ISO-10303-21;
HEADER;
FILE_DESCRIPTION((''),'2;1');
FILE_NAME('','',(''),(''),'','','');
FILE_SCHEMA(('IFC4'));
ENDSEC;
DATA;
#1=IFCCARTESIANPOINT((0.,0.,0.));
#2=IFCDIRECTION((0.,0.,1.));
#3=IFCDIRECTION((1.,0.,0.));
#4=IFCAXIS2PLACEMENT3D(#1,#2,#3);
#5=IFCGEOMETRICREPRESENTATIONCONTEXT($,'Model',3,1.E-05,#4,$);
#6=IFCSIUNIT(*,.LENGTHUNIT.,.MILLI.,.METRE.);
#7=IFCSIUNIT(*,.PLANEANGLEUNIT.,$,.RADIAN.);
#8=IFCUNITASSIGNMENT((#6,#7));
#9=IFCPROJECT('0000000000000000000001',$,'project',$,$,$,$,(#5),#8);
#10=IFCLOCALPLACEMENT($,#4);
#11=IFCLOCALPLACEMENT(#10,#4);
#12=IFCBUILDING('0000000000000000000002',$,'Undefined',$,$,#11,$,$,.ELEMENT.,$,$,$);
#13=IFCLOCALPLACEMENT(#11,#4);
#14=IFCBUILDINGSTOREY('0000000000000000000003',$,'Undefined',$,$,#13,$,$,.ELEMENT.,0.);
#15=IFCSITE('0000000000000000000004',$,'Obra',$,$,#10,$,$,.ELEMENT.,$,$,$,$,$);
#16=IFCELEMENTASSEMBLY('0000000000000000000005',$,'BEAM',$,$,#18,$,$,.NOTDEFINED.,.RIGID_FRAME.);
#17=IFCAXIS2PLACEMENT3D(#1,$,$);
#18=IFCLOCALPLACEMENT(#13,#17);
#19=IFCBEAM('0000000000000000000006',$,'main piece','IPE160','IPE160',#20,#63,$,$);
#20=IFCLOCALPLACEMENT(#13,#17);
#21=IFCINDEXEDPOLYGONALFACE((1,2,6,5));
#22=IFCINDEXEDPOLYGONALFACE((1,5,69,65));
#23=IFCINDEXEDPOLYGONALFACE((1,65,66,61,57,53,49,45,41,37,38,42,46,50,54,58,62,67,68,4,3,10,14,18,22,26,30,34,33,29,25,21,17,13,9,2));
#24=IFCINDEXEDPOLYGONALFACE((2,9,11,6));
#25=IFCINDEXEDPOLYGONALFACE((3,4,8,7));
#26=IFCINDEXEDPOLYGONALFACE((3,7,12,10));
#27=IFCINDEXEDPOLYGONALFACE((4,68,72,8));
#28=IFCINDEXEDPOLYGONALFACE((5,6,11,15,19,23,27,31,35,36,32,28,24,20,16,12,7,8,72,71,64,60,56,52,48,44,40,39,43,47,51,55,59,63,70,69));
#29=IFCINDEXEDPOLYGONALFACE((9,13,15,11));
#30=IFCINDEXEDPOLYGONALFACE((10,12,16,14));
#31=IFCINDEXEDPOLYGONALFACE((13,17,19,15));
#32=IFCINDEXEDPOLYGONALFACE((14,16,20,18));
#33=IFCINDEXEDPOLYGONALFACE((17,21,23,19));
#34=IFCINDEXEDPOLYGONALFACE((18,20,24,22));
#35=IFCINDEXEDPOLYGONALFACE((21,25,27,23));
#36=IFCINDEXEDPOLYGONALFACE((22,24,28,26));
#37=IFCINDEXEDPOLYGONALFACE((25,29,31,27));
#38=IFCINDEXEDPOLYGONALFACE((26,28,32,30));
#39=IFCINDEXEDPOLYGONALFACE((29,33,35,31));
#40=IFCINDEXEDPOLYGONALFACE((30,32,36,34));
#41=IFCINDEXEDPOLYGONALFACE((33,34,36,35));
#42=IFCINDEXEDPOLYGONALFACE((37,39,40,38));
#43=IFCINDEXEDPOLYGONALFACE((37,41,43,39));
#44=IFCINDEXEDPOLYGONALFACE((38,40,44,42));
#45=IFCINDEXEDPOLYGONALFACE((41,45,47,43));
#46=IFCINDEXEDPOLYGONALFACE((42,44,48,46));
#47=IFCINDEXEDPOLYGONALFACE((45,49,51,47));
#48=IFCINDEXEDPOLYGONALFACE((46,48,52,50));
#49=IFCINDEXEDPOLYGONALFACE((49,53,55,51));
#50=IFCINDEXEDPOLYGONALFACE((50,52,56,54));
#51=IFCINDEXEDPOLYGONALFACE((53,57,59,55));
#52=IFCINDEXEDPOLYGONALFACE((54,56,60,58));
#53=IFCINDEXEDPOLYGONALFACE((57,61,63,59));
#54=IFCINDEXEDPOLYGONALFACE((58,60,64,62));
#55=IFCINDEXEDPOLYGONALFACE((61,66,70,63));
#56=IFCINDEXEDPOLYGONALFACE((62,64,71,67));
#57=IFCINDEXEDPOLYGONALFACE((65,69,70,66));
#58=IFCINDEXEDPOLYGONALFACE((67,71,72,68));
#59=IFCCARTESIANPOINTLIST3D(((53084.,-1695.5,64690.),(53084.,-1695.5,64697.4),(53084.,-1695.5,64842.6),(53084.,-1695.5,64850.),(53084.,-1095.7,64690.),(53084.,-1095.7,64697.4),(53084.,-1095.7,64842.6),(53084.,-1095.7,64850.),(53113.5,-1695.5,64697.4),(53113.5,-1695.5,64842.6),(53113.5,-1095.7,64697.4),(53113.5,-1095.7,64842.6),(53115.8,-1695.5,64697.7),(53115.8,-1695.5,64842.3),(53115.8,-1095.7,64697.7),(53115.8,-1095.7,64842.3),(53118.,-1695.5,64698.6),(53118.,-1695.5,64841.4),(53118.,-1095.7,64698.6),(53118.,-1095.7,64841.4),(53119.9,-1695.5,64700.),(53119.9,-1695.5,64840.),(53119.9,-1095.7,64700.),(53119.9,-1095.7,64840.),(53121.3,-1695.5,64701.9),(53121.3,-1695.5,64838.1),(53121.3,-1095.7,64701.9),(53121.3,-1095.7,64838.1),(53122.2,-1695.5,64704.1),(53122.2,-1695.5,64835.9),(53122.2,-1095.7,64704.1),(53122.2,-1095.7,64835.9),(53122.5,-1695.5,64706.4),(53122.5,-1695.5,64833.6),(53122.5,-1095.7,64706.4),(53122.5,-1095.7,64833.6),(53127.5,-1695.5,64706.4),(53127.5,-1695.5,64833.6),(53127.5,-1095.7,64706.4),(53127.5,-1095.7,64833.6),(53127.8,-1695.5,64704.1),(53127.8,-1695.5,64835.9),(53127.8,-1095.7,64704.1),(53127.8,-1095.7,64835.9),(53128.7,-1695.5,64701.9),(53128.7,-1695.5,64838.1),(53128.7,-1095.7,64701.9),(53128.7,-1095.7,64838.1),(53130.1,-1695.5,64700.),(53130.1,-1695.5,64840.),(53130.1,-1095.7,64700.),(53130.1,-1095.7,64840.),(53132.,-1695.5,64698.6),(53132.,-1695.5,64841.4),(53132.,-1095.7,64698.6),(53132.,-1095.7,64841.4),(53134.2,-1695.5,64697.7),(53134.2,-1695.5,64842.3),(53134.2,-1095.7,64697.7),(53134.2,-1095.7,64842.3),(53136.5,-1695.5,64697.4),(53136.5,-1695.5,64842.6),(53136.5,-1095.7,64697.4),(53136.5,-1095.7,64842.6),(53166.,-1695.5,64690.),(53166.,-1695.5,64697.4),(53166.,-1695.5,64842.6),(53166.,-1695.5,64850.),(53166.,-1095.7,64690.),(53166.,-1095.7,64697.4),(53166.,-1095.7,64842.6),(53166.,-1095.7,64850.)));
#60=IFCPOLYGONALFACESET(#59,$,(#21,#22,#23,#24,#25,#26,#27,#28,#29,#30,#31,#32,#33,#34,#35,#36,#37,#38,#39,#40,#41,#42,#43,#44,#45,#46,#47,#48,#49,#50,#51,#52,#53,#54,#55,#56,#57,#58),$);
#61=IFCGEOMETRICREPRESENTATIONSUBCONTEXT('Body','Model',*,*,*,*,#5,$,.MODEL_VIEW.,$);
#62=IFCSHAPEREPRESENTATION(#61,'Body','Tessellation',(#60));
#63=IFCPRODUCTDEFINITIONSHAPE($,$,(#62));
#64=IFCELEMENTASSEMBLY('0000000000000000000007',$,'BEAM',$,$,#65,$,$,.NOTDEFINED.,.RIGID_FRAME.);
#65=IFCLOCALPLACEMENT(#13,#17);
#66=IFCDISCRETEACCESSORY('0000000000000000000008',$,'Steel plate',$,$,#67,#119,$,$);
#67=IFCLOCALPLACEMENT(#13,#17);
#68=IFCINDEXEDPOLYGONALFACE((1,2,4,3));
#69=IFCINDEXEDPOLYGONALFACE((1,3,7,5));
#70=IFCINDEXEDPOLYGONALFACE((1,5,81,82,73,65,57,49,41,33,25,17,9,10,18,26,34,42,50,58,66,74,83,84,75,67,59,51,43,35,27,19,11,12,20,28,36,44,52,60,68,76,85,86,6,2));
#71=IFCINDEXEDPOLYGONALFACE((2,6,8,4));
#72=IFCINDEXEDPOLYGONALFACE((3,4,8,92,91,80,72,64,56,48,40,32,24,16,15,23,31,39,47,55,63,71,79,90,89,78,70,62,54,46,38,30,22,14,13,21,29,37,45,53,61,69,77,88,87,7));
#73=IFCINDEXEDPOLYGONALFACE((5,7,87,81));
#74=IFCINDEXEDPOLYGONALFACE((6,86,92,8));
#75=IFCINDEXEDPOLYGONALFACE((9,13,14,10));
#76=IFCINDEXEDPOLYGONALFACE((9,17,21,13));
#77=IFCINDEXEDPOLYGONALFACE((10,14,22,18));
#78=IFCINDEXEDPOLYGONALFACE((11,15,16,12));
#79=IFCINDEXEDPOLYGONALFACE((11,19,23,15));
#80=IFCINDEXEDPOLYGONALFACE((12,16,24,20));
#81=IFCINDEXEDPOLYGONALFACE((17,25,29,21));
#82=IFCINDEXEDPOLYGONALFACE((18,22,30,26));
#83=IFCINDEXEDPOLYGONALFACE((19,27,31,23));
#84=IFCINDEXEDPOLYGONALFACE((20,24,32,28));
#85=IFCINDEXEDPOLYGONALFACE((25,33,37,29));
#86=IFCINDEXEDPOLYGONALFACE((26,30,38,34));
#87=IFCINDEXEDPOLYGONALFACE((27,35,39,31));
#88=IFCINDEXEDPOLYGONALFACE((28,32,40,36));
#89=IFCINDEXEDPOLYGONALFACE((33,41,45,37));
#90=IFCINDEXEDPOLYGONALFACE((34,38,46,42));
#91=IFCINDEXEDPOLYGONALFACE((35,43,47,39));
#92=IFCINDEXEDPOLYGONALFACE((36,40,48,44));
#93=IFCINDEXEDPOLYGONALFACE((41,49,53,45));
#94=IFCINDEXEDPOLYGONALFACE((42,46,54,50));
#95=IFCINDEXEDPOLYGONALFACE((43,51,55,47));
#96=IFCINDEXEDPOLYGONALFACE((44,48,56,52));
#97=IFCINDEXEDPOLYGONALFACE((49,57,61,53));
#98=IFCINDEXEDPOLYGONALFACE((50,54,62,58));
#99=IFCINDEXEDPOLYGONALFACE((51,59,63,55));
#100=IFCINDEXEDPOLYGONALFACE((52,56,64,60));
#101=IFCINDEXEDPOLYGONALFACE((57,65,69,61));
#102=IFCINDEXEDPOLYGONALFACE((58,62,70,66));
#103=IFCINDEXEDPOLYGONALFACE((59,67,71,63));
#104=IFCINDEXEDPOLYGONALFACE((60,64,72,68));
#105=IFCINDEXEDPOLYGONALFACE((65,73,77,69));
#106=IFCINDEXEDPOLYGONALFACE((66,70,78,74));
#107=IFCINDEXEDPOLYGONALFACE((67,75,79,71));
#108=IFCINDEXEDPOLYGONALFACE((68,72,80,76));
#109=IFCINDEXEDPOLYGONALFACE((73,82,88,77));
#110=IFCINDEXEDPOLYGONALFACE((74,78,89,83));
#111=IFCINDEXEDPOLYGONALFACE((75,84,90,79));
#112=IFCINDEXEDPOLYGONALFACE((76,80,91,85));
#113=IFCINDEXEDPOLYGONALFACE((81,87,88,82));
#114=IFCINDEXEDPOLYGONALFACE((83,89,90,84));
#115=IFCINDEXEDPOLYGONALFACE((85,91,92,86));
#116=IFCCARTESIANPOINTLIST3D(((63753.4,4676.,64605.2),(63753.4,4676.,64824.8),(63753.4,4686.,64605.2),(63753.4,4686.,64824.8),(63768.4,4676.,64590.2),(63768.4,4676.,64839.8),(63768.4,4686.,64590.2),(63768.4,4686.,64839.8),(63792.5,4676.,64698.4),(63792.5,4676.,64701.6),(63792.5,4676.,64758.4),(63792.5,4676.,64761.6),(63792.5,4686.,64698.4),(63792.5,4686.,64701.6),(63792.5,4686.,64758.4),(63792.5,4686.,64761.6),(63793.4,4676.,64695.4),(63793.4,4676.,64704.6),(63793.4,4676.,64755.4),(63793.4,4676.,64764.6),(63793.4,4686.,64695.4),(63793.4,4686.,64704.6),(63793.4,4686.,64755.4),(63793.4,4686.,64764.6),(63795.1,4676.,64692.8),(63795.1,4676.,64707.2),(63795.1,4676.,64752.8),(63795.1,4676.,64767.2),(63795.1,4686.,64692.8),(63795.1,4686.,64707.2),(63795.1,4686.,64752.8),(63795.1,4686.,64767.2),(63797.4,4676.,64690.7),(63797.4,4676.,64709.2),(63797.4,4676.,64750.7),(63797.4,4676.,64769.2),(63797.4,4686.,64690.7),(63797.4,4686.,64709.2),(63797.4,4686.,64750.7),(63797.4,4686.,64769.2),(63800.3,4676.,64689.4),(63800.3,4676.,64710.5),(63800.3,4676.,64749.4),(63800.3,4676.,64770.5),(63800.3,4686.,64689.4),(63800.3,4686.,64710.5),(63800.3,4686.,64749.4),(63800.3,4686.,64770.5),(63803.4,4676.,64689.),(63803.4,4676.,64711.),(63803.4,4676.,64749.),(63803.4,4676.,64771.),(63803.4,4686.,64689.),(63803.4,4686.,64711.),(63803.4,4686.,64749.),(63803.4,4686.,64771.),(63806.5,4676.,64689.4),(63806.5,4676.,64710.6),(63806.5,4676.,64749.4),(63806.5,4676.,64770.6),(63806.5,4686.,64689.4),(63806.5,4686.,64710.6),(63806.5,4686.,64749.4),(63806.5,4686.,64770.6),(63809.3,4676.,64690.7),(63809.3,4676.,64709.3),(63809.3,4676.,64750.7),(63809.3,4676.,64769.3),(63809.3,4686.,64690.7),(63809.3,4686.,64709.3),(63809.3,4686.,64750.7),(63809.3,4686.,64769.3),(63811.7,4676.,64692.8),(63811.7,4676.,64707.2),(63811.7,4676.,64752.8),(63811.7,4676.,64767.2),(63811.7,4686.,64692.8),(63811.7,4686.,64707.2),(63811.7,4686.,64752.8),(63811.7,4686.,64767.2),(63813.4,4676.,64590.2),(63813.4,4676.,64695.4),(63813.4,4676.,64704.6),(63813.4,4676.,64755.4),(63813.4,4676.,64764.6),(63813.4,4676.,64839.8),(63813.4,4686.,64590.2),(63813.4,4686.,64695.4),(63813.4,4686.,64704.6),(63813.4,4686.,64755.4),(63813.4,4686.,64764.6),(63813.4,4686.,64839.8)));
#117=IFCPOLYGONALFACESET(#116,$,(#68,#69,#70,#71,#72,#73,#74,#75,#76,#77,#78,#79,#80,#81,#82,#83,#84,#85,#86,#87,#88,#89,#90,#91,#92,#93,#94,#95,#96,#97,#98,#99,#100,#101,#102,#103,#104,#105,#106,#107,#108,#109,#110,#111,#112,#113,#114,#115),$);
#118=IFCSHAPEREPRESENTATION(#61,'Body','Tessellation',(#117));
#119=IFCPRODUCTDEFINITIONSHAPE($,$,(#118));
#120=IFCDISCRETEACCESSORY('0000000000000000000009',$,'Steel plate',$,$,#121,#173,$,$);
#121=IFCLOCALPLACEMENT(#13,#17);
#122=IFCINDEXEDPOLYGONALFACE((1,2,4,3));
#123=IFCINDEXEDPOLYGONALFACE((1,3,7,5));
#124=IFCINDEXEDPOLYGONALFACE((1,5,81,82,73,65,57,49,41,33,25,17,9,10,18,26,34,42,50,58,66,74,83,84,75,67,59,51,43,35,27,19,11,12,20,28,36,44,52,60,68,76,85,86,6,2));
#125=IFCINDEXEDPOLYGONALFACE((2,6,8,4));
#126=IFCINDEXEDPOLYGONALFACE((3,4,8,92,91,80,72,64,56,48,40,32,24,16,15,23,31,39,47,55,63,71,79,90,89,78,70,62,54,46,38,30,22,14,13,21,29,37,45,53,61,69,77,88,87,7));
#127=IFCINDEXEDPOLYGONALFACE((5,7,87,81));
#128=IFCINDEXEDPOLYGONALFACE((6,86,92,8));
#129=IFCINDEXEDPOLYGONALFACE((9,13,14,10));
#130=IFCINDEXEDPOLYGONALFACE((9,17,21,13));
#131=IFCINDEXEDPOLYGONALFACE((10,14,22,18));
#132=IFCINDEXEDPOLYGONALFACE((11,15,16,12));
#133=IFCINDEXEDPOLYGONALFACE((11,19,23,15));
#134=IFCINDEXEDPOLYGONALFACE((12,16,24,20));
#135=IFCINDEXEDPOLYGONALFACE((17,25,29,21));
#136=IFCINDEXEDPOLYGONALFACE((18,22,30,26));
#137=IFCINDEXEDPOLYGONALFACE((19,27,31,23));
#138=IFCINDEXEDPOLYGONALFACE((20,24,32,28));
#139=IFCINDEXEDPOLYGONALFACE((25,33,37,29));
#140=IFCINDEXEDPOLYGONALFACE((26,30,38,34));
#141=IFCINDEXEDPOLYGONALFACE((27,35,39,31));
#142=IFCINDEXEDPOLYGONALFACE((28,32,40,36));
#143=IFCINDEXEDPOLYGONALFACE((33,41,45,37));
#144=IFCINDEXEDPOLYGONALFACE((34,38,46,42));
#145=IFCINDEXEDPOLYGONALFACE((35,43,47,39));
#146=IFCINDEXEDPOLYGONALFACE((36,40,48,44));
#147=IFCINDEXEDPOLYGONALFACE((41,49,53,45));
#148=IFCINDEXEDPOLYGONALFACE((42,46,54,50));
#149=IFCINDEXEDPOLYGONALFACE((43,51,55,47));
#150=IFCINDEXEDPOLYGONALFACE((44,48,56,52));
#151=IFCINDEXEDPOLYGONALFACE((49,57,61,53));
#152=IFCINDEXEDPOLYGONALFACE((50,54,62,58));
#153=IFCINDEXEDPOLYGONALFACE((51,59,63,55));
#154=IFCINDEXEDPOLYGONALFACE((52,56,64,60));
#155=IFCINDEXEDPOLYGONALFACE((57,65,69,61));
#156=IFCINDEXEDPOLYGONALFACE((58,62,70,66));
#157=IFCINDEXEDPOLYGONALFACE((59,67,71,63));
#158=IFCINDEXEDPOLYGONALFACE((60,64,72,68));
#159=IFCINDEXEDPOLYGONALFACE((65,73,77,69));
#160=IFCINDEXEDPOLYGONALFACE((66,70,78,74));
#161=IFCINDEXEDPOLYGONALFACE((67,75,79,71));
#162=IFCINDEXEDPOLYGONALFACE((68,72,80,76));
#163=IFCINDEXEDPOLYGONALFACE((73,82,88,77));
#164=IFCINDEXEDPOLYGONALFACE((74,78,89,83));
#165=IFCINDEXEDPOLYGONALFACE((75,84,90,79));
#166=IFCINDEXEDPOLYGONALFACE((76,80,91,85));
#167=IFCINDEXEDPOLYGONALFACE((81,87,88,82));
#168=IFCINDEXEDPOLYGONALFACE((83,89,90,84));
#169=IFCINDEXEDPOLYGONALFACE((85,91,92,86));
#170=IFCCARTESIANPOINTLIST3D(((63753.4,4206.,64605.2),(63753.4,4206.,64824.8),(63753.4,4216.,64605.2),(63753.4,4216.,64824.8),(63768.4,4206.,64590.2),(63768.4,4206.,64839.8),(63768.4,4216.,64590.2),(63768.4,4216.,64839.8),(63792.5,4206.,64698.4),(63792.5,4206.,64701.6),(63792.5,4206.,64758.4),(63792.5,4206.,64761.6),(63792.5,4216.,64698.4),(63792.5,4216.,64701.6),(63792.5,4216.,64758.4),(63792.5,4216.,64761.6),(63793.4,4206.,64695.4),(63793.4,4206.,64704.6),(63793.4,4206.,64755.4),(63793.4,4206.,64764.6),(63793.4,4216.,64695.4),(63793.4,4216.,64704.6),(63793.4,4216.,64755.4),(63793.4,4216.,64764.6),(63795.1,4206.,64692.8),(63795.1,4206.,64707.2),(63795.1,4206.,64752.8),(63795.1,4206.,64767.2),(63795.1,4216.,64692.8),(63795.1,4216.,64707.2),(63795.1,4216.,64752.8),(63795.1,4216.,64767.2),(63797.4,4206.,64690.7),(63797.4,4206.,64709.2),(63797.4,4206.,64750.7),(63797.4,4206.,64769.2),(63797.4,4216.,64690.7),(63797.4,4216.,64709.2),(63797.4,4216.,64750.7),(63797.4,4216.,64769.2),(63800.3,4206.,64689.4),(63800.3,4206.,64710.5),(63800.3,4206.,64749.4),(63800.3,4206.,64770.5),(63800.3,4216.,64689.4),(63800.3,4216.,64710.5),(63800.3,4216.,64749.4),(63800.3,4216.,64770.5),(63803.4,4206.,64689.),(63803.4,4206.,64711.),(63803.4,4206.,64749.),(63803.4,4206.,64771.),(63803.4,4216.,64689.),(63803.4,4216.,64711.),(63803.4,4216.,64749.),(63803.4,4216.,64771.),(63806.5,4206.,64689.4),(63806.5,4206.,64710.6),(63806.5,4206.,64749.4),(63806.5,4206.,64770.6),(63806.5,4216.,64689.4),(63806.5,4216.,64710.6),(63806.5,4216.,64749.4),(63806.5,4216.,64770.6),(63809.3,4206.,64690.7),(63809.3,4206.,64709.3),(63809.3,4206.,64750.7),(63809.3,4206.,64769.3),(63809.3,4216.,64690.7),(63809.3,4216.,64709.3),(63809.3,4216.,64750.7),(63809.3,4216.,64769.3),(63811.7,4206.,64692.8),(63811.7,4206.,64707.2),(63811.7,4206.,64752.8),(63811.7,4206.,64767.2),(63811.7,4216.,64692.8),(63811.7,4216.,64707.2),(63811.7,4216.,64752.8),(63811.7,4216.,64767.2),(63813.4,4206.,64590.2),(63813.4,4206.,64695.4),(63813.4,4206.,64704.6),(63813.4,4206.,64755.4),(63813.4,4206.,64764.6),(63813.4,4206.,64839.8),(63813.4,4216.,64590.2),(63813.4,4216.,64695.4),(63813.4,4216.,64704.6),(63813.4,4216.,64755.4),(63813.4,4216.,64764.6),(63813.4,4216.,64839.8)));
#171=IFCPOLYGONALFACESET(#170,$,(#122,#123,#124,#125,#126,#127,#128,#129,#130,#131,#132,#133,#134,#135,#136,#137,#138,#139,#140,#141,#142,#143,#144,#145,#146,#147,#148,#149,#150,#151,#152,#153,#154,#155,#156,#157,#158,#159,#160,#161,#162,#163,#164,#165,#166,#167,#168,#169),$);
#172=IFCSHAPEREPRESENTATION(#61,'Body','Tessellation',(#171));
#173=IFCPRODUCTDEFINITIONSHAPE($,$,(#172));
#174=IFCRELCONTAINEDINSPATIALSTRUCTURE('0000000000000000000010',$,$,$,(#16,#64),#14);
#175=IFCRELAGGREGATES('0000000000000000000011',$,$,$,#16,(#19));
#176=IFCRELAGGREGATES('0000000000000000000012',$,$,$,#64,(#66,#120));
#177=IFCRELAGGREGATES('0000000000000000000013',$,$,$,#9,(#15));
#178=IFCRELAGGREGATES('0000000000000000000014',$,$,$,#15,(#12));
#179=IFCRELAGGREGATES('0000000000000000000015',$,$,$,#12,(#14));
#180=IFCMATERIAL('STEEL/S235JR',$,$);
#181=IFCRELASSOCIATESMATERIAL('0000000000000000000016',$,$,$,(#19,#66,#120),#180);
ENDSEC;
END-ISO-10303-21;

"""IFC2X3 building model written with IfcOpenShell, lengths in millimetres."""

from ifc_helpers import new_model, si_unit, frame, origin_with_axes, origin_2d_with_axis, place, context, subcontext, project, spatial, polyline, circle, i_section, outline, extrude, source, transform, mapped, material, element, aggregate, save


model = new_model("IFC2X3")

# Units and contexts
model_context = context("Model", 3, precision=1e-05, world=origin_with_axes())
body_context = subcontext(model_context, "Body", "Model", "MODEL_VIEW")
ifc_project = project(units=[si_unit("LENGTHUNIT", "METRE", prefix="MILLI"), si_unit("PLANEANGLEUNIT", "RADIAN")], contexts=[model_context])

# Site, building, storey
site_placement = place(None, origin_with_axes())
site = spatial("IfcSite", under=ifc_project, at=site_placement, Name="Obra", CompositionType="ELEMENT")
building_placement = place(site_placement, origin_with_axes())
building = spatial("IfcBuilding", under=site, at=building_placement, Name="Undefined", CompositionType="ELEMENT")
storey_placement = place(building_placement, origin_with_axes())
storey = spatial("IfcBuildingStorey", under=building, at=storey_placement, Name="Undefined", CompositionType="ELEMENT", Elevation=0.0)

# Element assembly, beam
ifc_material_1 = material(Name="STEEL/S235JR")
assembly_1_placement = place(storey_placement, origin_with_axes())
assembly_1 = element("IfcElementAssembly", 1, at=assembly_1_placement, inside=storey, Name="BEAM", AssemblyPlace="NOTDEFINED", PredefinedType="RIGID_FRAME")
beam_1_placement = place(assembly_1_placement, frame((53125.0, -1095.7, 64770.0), z_axis=(0.0, 0.0, 1.0), x_axis=(0.0, -1.0, 0.0)))
beam_1 = element("IfcBeam", 2, at=beam_1_placement, material=ifc_material_1, Name="main piece", Description="IPE160", ObjectType="IPE160", context=body_context, shape_type="SweptSolid", body=[
    extrude(i_section(OverallWidth=82.0, OverallDepth=160.0, WebThickness=5.0, FlangeThickness=7.4, FilletRadius=9.0, at=origin_2d_with_axis()), frame((599.8, 0.0, 0.0), z_axis=(-1.0, 0.0, 0.0), x_axis=(0.0, -1.0, 0.0)), (0.0, 0.0, 1.0), 599.8),
])
aggregate(assembly_1, [beam_1])

# Element assembly
assembly_2_placement = place(storey_placement, origin_with_axes())
assembly_2 = element("IfcElementAssembly", 3, at=assembly_2_placement, inside=storey, Name="BEAM", AssemblyPlace="NOTDEFINED", PredefinedType="RIGID_FRAME")

# Discrete accessories, openings
discrete_accessory_1_placement = place(assembly_2_placement, frame((63813.4, 4681.0, 64590.2), z_axis=(0.0, 1.0, 0.0), x_axis=(-1.0, 0.0, 0.0)))
discrete_accessory_1 = element("IfcDiscreteAccessory", 4, at=discrete_accessory_1_placement, material=ifc_material_1, Name="Steel plate", context=body_context, shape_type="SweptSolid", body=[
    extrude(outline(polyline([(0.0, 0.0), (45.0, 0.0), (60.0, 15.0), (60.0, 234.6), (45.0, 249.6), (0.0, 249.6), (0.0, 0.0)])), frame((0.0, 0.0, -5.0), z_axis=(0.0, 0.0, 1.0), x_axis=(1.0, 0.0, 0.0)), (0.0, 0.0, 1.0), 10.0),
])
shared_shape_1 = source(origin_with_axes(), body_context, "Body", "SweptSolid", [
    extrude(circle(Radius=11.0, at=origin_2d_with_axis()), frame((0.0, -13.2, 0.0), z_axis=(0.0, 1.0, 0.0), x_axis=(1.0, 0.0, 0.0)), (0.0, 0.0, 1.0), 10.2),
])
opening_1_placement = place(assembly_2_placement, frame((63763.4, 4689.1, 64850.0), z_axis=(1.0, 0.0, 0.0), x_axis=(0.0, 0.0, -1.0)))
element("IfcOpeningElement", 5, at=opening_1_placement, cuts=discrete_accessory_1, ObjectType="Opening", context=body_context, shape_type="MappedRepresentation", body=[
    mapped(shared_shape_1, transform((90.0, 0.0, 40.0))),
    mapped(shared_shape_1, transform((150.0, 0.0, 40.0))),
])
discrete_accessory_2_placement = place(assembly_2_placement, frame((63813.4, 4211.0, 64590.2), z_axis=(0.0, 1.0, 0.0), x_axis=(-1.0, 0.0, 0.0)))
discrete_accessory_2 = element("IfcDiscreteAccessory", 6, at=discrete_accessory_2_placement, material=ifc_material_1, Name="Steel plate", context=body_context, shape_type="SweptSolid", body=[
    extrude(outline(polyline([(0.0, 0.0), (45.0, 0.0), (60.0, 15.0), (60.0, 234.6), (45.0, 249.6), (0.0, 249.6), (0.0, 0.0)])), frame((0.0, 0.0, -5.0), z_axis=(0.0, 0.0, 1.0), x_axis=(1.0, 0.0, 0.0)), (0.0, 0.0, 1.0), 10.0),
])
opening_2_placement = place(assembly_2_placement, frame((63763.4, 4219.1, 64850.0), z_axis=(1.0, 0.0, 0.0), x_axis=(0.0, 0.0, -1.0)))
element("IfcOpeningElement", 7, at=opening_2_placement, cuts=discrete_accessory_2, ObjectType="Opening", context=body_context, shape_type="MappedRepresentation", body=[
    mapped(shared_shape_1, transform((90.0, 0.0, 40.0))),
    mapped(shared_shape_1, transform((150.0, 0.0, 40.0))),
])
aggregate(assembly_2, [discrete_accessory_1, discrete_accessory_2])

save(model, "model.ifc")
